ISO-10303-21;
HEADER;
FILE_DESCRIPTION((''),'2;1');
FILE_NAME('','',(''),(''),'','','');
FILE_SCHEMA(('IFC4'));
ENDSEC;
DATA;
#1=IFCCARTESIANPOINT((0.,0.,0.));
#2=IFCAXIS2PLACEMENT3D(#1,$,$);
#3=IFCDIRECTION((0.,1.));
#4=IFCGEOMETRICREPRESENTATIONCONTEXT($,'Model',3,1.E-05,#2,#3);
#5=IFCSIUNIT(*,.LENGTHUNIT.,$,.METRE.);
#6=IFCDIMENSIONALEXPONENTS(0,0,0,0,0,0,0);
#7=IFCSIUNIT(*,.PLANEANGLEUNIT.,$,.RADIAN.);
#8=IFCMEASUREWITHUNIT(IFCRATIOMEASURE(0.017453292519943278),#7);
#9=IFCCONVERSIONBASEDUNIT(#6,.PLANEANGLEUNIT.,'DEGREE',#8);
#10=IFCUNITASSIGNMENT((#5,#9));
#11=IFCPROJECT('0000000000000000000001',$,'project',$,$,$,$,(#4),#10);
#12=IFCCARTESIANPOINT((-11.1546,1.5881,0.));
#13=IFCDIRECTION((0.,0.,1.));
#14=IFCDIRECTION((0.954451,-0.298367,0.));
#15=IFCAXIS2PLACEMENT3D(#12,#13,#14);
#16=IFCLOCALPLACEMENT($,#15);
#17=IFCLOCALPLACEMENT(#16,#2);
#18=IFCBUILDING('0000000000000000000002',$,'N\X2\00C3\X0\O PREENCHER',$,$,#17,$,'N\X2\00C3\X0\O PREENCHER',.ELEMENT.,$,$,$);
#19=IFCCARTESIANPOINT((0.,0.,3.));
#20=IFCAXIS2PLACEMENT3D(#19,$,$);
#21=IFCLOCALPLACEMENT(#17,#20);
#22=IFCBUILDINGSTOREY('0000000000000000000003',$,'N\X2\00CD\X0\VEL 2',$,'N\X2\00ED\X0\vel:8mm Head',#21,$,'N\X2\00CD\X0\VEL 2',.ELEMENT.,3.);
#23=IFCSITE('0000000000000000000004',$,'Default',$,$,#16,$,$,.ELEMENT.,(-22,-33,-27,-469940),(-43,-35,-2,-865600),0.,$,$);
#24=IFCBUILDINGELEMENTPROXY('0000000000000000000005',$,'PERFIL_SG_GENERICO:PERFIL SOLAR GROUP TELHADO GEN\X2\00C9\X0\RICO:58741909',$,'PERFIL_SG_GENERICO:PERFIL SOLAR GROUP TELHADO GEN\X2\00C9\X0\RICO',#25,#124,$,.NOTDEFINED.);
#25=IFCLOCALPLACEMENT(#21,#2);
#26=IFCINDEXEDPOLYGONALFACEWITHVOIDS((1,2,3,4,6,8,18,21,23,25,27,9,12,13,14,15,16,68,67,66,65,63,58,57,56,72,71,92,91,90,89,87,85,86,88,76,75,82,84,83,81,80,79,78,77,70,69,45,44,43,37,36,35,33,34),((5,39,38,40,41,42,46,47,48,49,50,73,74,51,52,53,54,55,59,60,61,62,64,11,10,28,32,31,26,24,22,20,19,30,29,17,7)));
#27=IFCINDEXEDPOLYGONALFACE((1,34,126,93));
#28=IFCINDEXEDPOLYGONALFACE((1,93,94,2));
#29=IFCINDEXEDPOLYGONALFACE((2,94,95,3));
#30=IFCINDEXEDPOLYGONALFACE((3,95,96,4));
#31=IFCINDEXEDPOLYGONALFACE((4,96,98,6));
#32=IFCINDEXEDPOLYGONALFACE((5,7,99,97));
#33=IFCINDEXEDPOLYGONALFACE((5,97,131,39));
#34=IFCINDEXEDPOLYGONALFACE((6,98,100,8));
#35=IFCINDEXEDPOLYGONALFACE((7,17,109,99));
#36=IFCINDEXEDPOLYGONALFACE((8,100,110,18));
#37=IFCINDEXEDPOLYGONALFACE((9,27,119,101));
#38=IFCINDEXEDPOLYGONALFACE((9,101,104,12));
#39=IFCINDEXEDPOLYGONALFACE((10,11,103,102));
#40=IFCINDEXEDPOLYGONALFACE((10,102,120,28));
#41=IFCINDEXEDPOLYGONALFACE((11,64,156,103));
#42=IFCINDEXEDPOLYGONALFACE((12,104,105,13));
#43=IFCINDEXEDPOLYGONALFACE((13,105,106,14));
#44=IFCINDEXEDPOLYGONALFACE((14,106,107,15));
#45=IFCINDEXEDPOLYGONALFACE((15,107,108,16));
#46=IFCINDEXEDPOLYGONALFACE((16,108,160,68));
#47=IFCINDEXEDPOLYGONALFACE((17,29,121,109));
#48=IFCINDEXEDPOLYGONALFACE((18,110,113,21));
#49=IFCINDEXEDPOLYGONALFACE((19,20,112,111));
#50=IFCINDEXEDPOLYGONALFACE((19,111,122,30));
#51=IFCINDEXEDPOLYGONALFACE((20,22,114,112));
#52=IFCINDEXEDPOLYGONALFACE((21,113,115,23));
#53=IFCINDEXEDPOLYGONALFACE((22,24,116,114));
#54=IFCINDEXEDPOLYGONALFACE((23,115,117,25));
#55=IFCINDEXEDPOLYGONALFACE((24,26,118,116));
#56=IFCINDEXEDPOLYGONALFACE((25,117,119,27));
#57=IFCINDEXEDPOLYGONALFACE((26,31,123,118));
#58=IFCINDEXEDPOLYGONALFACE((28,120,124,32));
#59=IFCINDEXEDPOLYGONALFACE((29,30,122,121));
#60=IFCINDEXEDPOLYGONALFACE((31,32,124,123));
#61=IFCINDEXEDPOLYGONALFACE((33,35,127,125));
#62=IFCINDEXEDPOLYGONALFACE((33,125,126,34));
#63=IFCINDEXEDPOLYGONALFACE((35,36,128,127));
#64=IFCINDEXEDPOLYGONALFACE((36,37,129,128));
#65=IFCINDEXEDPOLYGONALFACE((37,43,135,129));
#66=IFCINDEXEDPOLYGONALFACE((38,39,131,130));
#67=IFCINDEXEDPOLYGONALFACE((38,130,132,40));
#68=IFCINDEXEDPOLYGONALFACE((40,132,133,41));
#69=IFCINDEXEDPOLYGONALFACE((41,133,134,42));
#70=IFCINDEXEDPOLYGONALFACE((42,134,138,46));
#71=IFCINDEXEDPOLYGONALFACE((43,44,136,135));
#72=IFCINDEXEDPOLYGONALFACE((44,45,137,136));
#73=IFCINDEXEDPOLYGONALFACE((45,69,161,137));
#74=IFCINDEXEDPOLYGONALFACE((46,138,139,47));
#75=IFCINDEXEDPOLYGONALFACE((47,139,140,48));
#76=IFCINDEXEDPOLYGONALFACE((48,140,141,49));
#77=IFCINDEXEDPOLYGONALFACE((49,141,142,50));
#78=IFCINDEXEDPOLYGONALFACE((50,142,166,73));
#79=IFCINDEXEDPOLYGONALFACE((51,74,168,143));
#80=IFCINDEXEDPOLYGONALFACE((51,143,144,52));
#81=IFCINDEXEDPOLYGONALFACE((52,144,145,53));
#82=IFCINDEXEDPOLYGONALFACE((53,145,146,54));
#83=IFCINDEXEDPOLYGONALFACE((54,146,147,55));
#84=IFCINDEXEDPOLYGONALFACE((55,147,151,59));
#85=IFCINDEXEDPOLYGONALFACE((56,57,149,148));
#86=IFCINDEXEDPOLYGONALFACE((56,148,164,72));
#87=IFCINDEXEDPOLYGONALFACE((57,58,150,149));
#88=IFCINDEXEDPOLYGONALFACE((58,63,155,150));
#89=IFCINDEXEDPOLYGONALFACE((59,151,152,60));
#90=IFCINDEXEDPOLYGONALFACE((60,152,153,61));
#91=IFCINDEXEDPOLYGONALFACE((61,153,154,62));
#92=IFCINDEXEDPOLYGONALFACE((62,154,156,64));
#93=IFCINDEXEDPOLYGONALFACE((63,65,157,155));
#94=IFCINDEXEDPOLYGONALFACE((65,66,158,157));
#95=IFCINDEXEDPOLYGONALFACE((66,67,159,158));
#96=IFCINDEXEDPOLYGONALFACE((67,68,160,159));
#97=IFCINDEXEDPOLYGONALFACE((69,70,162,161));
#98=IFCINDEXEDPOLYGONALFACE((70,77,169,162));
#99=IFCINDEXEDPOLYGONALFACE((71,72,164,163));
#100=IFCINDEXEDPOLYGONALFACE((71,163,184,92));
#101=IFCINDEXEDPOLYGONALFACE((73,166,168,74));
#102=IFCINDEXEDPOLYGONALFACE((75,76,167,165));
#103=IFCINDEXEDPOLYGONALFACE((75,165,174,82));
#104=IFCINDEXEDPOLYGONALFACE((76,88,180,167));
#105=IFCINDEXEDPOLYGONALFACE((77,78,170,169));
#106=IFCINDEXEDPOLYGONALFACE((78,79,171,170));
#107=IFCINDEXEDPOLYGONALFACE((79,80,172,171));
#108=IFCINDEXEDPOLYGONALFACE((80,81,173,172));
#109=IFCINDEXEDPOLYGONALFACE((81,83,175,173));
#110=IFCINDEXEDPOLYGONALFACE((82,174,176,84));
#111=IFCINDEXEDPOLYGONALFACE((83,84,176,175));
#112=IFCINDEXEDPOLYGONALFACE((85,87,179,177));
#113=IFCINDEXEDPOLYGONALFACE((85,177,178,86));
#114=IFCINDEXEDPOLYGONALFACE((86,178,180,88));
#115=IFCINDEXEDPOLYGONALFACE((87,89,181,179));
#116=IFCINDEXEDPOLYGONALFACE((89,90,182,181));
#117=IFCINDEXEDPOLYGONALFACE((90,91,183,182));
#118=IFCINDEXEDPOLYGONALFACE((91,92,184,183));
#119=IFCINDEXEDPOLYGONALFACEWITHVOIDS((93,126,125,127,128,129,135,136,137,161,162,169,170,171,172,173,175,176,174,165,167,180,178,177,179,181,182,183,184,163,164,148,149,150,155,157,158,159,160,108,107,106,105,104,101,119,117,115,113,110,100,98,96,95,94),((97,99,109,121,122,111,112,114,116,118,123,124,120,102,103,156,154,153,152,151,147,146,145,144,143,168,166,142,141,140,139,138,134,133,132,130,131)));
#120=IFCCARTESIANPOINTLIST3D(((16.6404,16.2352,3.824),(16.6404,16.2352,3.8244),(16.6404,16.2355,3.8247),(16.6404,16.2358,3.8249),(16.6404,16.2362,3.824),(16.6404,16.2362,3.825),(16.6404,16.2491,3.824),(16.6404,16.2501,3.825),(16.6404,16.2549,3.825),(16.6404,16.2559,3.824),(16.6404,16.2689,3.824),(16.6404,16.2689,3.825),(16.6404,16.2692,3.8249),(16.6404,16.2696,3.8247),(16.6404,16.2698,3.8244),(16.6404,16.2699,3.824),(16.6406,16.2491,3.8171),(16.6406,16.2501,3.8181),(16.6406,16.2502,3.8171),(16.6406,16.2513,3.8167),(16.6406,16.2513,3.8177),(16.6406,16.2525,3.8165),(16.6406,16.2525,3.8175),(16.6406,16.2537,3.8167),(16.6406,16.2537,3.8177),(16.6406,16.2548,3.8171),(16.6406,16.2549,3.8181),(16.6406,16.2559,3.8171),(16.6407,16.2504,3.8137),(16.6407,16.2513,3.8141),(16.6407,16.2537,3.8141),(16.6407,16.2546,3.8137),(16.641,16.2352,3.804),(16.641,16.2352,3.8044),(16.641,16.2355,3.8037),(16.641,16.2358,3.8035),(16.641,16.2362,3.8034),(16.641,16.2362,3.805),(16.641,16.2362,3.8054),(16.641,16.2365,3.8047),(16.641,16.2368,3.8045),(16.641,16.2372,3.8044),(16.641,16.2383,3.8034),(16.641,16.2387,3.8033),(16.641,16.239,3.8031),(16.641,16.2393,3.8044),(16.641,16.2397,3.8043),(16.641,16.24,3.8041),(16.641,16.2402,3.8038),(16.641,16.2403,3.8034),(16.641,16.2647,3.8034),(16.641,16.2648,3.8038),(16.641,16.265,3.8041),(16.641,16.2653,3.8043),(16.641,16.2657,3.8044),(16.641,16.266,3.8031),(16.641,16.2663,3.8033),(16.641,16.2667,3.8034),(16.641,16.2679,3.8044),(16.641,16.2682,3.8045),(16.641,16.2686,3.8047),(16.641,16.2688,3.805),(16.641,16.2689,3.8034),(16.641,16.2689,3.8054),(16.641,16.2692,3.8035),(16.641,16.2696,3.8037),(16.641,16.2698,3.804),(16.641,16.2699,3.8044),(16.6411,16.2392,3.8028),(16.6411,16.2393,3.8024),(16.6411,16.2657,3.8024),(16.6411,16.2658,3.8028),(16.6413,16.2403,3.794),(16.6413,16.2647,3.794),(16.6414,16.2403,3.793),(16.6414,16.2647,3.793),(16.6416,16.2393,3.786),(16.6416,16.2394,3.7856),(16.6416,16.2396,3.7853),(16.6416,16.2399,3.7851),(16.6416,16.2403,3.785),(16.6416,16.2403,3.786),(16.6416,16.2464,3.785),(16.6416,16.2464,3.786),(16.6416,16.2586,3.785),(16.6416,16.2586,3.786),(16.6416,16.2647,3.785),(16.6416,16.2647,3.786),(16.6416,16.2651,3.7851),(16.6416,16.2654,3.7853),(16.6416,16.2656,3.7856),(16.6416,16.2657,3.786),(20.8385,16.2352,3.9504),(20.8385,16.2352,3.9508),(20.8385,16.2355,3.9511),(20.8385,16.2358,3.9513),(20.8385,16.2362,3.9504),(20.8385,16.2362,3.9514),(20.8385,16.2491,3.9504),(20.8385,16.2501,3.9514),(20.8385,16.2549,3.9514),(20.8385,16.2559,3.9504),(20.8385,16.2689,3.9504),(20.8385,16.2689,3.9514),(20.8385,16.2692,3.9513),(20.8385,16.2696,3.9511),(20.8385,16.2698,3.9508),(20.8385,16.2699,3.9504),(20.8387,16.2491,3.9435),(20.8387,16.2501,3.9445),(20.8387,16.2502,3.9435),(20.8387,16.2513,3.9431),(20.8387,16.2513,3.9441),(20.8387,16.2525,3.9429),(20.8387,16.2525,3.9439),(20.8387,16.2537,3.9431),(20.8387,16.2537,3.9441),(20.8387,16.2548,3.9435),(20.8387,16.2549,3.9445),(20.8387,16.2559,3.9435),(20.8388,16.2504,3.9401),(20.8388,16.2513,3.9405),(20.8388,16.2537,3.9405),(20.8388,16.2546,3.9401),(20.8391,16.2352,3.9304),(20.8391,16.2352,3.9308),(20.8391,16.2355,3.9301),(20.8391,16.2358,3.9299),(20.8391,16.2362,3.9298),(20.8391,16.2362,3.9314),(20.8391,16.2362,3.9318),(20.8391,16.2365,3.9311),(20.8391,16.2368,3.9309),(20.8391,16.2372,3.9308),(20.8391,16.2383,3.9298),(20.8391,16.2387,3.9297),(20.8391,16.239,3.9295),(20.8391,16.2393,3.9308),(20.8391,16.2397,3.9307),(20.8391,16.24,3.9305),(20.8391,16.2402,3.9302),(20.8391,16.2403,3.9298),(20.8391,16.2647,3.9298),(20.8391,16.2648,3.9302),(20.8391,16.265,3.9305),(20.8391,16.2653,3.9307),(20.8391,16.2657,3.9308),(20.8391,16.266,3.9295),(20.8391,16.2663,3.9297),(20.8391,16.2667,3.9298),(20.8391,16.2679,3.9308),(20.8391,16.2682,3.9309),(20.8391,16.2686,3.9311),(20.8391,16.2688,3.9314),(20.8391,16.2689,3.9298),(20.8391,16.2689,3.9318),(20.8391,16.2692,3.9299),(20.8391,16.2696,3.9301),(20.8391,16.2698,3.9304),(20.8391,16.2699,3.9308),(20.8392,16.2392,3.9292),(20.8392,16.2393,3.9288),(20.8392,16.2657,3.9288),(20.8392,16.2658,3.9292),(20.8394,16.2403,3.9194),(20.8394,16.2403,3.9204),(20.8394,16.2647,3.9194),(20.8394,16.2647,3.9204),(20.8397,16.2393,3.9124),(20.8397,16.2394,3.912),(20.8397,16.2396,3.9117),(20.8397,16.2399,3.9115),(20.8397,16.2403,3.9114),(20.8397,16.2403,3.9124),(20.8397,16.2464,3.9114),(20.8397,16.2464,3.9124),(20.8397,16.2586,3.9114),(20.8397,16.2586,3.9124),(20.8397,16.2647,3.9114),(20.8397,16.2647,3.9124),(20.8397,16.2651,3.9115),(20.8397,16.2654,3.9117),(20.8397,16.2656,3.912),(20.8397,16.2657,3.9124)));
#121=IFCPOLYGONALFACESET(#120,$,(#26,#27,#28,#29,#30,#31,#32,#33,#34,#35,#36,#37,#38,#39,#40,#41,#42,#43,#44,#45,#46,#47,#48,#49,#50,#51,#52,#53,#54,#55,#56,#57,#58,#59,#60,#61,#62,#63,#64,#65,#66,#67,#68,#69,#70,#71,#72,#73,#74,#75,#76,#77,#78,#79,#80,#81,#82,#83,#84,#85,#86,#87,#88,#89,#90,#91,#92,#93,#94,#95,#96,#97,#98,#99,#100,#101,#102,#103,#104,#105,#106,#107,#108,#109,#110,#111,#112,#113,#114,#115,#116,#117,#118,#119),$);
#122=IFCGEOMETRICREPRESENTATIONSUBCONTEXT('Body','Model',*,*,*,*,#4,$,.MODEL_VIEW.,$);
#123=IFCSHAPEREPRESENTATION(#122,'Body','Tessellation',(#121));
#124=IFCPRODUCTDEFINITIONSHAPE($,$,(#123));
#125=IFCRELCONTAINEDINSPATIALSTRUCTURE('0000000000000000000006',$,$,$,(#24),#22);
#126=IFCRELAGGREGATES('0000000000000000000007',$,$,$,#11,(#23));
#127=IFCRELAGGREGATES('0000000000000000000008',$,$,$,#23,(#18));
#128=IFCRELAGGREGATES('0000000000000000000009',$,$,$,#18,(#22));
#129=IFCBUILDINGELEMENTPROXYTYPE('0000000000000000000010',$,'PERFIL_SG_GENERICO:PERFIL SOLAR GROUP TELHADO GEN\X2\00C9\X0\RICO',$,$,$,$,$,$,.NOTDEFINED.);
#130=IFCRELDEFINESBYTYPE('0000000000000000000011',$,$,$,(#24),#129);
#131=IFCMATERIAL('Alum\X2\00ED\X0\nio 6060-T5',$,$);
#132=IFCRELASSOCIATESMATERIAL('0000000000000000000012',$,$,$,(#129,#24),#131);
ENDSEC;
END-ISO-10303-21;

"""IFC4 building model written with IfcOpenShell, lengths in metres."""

from ifc_helpers import new_model, entity, si_unit, converted_unit, direction, frame, origin, place, context, subcontext, project, spatial, line, arc, indexed_curve, outline, extrude, source, transform, mapped, material, type_object, type_shapes, element, save


model = new_model("IFC4")

# Units and contexts
model_context = context("Model", 3, precision=1e-05, world=origin(), true_north=direction((0.0, 1.0)))
body_context = subcontext(model_context, "Body", "Model", "MODEL_VIEW")
ifc_project = project(units=[si_unit("LENGTHUNIT", "METRE"), converted_unit("PLANEANGLEUNIT", "DEGREE", entity("IfcRatioMeasure", 0.017453292519943278), si_unit("PLANEANGLEUNIT", "RADIAN"), dimensions=[0, 0, 0, 0, 0, 0, 0])], contexts=[model_context])

# Site, building, storey
site_placement = place(None, frame((-11.1546, 1.5881, 0.0), z_axis=(0.0, 0.0, 1.0), x_axis=(0.954451, -0.298367, 0.0)))
site = spatial("IfcSite", under=ifc_project, at=site_placement, Name="Default", CompositionType="ELEMENT", RefLatitude=(-22, -33, -27, -469940), RefLongitude=(-43, -35, -2, -865600), RefElevation=0.0)
building_placement = place(site_placement, origin())
building = spatial("IfcBuilding", under=site, at=building_placement, Name="NÃO PREENCHER", LongName="NÃO PREENCHER", CompositionType="ELEMENT")
storey_placement = place(building_placement, frame((0.0, 0.0, 3.0)))
storey = spatial("IfcBuildingStorey", under=building, at=storey_placement, Name="NÍVEL 2", ObjectType="Nível:8mm Head", LongName="NÍVEL 2", CompositionType="ELEMENT", Elevation=3.0)

# Building element proxy
ifc_material_1 = material(Name="Alumínio 6060-T5")
building_element_proxy_type_1 = type_object("IfcBuildingElementProxyType", Name="PERFIL_SG_GENERICO:PERFIL SOLAR GROUP TELHADO GENÉRICO", PredefinedType="NOTDEFINED", material=ifc_material_1)
shared_shape_1 = source(origin(), body_context, "Body", "SweptSolid", [
    extrude(outline(indexed_curve([(-0.0122, -0.0169), (-0.0061, -0.0169), (-0.0061, -0.0159), (-0.0122, -0.0159), (-0.0122, -0.0089), (0.0122, -0.0089), (0.0122, -0.0159), (0.0061, -0.0159), (0.0061, -0.0169), (0.0122, -0.0169), (0.0129, -0.0166), (0.0132, -0.0159), (0.0132, 0.0005), (0.0135, 0.0012), (0.0142, 0.0015), (0.0164, 0.0015), (0.0171, 0.0018), (0.0174, 0.0025), (0.0174, 0.0221), (0.0171, 0.0228), (0.0164, 0.0231), (0.0024, 0.0231), (0.0024, 0.0162), (0.0, 0.0156), (-0.0024, 0.0162), (-0.0024, 0.0231), (-0.0164, 0.0231), (-0.0171, 0.0228), (-0.0174, 0.0221), (-0.0174, 0.0025), (-0.0171, 0.0018), (-0.0164, 0.0015), (-0.0142, 0.0015), (-0.0135, 0.0012), (-0.0132, 0.0005), (-0.0132, -0.0159), (-0.0129, -0.0166)], segments=[line(1, 2, 3, 4, 5, 6, 7, 8, 9, 10), arc(10, 11, 12), line(12, 13), arc(13, 14, 15), line(15, 16), arc(16, 17, 18), line(18, 19), arc(19, 20, 21), line(21, 22, 23), arc(23, 24, 25), line(25, 26, 27), arc(27, 28, 29), line(29, 30), arc(30, 31, 32), line(32, 33), arc(33, 34, 35), line(35, 36), arc(36, 37, 1)], self_intersect=False), holes=[indexed_curve([(-0.0122, -0.0079), (-0.0122, 0.0015), (-0.0125, 0.0022), (-0.0132, 0.0025), (-0.0154, 0.0025), (-0.0161, 0.0028), (-0.0164, 0.0035), (-0.0164, 0.0221), (-0.0034, 0.0221), (-0.0034, 0.0152), (-0.0021, 0.0118), (-0.0012, 0.0122), (-0.0023, 0.0151), (0.0, 0.0146), (0.0023, 0.0151), (0.0012, 0.0122), (0.0021, 0.0118), (0.0034, 0.0152), (0.0034, 0.0221), (0.0164, 0.0221), (0.0164, 0.0035), (0.0161, 0.0028), (0.0154, 0.0025), (0.0132, 0.0025), (0.0125, 0.0022), (0.0122, 0.0015), (0.0122, -0.0079)], segments=[line(1, 2), arc(2, 3, 4), line(4, 5), arc(5, 6, 7), line(7, 8, 9, 10, 11, 12, 13), arc(13, 14, 15), line(15, 16, 17, 18, 19, 20, 21), arc(21, 22, 23), line(23, 24), arc(24, 25, 26), line(26, 27, 1)], self_intersect=False)]), frame((0.0, 0.0, 0.0169), z_axis=(1.0, 0.0, 0.0), x_axis=(0.0, 1.0, 0.0)), (0.0, 0.0, 1.0), 4.2),
])
type_shapes(building_element_proxy_type_1, [shared_shape_1])
for number, where, z_axis, x_axis, name in (
    (1, (16.6416, 16.2525, 3.785), (-0.030095, 0.0, 0.999547), (0.999547, 0.0, 0.030095), "PERFIL_SG_GENERICO:PERFIL SOLAR GROUP TELHADO GENÉRICO:58741909"),
):
    element("IfcBuildingElementProxy", number, at=place(storey_placement, frame(where, z_axis=z_axis, x_axis=x_axis)), inside=storey, type_object=building_element_proxy_type_1, material=ifc_material_1, Name=name, ObjectType="PERFIL_SG_GENERICO:PERFIL SOLAR GROUP TELHADO GENÉRICO", PredefinedType="NOTDEFINED", context=body_context, shape_type="MappedRepresentation", body=[
        mapped(shared_shape_1, transform((0.0, 0.0, 0.0), scale=1.0)),
    ])

save(model, "model.ifc")
